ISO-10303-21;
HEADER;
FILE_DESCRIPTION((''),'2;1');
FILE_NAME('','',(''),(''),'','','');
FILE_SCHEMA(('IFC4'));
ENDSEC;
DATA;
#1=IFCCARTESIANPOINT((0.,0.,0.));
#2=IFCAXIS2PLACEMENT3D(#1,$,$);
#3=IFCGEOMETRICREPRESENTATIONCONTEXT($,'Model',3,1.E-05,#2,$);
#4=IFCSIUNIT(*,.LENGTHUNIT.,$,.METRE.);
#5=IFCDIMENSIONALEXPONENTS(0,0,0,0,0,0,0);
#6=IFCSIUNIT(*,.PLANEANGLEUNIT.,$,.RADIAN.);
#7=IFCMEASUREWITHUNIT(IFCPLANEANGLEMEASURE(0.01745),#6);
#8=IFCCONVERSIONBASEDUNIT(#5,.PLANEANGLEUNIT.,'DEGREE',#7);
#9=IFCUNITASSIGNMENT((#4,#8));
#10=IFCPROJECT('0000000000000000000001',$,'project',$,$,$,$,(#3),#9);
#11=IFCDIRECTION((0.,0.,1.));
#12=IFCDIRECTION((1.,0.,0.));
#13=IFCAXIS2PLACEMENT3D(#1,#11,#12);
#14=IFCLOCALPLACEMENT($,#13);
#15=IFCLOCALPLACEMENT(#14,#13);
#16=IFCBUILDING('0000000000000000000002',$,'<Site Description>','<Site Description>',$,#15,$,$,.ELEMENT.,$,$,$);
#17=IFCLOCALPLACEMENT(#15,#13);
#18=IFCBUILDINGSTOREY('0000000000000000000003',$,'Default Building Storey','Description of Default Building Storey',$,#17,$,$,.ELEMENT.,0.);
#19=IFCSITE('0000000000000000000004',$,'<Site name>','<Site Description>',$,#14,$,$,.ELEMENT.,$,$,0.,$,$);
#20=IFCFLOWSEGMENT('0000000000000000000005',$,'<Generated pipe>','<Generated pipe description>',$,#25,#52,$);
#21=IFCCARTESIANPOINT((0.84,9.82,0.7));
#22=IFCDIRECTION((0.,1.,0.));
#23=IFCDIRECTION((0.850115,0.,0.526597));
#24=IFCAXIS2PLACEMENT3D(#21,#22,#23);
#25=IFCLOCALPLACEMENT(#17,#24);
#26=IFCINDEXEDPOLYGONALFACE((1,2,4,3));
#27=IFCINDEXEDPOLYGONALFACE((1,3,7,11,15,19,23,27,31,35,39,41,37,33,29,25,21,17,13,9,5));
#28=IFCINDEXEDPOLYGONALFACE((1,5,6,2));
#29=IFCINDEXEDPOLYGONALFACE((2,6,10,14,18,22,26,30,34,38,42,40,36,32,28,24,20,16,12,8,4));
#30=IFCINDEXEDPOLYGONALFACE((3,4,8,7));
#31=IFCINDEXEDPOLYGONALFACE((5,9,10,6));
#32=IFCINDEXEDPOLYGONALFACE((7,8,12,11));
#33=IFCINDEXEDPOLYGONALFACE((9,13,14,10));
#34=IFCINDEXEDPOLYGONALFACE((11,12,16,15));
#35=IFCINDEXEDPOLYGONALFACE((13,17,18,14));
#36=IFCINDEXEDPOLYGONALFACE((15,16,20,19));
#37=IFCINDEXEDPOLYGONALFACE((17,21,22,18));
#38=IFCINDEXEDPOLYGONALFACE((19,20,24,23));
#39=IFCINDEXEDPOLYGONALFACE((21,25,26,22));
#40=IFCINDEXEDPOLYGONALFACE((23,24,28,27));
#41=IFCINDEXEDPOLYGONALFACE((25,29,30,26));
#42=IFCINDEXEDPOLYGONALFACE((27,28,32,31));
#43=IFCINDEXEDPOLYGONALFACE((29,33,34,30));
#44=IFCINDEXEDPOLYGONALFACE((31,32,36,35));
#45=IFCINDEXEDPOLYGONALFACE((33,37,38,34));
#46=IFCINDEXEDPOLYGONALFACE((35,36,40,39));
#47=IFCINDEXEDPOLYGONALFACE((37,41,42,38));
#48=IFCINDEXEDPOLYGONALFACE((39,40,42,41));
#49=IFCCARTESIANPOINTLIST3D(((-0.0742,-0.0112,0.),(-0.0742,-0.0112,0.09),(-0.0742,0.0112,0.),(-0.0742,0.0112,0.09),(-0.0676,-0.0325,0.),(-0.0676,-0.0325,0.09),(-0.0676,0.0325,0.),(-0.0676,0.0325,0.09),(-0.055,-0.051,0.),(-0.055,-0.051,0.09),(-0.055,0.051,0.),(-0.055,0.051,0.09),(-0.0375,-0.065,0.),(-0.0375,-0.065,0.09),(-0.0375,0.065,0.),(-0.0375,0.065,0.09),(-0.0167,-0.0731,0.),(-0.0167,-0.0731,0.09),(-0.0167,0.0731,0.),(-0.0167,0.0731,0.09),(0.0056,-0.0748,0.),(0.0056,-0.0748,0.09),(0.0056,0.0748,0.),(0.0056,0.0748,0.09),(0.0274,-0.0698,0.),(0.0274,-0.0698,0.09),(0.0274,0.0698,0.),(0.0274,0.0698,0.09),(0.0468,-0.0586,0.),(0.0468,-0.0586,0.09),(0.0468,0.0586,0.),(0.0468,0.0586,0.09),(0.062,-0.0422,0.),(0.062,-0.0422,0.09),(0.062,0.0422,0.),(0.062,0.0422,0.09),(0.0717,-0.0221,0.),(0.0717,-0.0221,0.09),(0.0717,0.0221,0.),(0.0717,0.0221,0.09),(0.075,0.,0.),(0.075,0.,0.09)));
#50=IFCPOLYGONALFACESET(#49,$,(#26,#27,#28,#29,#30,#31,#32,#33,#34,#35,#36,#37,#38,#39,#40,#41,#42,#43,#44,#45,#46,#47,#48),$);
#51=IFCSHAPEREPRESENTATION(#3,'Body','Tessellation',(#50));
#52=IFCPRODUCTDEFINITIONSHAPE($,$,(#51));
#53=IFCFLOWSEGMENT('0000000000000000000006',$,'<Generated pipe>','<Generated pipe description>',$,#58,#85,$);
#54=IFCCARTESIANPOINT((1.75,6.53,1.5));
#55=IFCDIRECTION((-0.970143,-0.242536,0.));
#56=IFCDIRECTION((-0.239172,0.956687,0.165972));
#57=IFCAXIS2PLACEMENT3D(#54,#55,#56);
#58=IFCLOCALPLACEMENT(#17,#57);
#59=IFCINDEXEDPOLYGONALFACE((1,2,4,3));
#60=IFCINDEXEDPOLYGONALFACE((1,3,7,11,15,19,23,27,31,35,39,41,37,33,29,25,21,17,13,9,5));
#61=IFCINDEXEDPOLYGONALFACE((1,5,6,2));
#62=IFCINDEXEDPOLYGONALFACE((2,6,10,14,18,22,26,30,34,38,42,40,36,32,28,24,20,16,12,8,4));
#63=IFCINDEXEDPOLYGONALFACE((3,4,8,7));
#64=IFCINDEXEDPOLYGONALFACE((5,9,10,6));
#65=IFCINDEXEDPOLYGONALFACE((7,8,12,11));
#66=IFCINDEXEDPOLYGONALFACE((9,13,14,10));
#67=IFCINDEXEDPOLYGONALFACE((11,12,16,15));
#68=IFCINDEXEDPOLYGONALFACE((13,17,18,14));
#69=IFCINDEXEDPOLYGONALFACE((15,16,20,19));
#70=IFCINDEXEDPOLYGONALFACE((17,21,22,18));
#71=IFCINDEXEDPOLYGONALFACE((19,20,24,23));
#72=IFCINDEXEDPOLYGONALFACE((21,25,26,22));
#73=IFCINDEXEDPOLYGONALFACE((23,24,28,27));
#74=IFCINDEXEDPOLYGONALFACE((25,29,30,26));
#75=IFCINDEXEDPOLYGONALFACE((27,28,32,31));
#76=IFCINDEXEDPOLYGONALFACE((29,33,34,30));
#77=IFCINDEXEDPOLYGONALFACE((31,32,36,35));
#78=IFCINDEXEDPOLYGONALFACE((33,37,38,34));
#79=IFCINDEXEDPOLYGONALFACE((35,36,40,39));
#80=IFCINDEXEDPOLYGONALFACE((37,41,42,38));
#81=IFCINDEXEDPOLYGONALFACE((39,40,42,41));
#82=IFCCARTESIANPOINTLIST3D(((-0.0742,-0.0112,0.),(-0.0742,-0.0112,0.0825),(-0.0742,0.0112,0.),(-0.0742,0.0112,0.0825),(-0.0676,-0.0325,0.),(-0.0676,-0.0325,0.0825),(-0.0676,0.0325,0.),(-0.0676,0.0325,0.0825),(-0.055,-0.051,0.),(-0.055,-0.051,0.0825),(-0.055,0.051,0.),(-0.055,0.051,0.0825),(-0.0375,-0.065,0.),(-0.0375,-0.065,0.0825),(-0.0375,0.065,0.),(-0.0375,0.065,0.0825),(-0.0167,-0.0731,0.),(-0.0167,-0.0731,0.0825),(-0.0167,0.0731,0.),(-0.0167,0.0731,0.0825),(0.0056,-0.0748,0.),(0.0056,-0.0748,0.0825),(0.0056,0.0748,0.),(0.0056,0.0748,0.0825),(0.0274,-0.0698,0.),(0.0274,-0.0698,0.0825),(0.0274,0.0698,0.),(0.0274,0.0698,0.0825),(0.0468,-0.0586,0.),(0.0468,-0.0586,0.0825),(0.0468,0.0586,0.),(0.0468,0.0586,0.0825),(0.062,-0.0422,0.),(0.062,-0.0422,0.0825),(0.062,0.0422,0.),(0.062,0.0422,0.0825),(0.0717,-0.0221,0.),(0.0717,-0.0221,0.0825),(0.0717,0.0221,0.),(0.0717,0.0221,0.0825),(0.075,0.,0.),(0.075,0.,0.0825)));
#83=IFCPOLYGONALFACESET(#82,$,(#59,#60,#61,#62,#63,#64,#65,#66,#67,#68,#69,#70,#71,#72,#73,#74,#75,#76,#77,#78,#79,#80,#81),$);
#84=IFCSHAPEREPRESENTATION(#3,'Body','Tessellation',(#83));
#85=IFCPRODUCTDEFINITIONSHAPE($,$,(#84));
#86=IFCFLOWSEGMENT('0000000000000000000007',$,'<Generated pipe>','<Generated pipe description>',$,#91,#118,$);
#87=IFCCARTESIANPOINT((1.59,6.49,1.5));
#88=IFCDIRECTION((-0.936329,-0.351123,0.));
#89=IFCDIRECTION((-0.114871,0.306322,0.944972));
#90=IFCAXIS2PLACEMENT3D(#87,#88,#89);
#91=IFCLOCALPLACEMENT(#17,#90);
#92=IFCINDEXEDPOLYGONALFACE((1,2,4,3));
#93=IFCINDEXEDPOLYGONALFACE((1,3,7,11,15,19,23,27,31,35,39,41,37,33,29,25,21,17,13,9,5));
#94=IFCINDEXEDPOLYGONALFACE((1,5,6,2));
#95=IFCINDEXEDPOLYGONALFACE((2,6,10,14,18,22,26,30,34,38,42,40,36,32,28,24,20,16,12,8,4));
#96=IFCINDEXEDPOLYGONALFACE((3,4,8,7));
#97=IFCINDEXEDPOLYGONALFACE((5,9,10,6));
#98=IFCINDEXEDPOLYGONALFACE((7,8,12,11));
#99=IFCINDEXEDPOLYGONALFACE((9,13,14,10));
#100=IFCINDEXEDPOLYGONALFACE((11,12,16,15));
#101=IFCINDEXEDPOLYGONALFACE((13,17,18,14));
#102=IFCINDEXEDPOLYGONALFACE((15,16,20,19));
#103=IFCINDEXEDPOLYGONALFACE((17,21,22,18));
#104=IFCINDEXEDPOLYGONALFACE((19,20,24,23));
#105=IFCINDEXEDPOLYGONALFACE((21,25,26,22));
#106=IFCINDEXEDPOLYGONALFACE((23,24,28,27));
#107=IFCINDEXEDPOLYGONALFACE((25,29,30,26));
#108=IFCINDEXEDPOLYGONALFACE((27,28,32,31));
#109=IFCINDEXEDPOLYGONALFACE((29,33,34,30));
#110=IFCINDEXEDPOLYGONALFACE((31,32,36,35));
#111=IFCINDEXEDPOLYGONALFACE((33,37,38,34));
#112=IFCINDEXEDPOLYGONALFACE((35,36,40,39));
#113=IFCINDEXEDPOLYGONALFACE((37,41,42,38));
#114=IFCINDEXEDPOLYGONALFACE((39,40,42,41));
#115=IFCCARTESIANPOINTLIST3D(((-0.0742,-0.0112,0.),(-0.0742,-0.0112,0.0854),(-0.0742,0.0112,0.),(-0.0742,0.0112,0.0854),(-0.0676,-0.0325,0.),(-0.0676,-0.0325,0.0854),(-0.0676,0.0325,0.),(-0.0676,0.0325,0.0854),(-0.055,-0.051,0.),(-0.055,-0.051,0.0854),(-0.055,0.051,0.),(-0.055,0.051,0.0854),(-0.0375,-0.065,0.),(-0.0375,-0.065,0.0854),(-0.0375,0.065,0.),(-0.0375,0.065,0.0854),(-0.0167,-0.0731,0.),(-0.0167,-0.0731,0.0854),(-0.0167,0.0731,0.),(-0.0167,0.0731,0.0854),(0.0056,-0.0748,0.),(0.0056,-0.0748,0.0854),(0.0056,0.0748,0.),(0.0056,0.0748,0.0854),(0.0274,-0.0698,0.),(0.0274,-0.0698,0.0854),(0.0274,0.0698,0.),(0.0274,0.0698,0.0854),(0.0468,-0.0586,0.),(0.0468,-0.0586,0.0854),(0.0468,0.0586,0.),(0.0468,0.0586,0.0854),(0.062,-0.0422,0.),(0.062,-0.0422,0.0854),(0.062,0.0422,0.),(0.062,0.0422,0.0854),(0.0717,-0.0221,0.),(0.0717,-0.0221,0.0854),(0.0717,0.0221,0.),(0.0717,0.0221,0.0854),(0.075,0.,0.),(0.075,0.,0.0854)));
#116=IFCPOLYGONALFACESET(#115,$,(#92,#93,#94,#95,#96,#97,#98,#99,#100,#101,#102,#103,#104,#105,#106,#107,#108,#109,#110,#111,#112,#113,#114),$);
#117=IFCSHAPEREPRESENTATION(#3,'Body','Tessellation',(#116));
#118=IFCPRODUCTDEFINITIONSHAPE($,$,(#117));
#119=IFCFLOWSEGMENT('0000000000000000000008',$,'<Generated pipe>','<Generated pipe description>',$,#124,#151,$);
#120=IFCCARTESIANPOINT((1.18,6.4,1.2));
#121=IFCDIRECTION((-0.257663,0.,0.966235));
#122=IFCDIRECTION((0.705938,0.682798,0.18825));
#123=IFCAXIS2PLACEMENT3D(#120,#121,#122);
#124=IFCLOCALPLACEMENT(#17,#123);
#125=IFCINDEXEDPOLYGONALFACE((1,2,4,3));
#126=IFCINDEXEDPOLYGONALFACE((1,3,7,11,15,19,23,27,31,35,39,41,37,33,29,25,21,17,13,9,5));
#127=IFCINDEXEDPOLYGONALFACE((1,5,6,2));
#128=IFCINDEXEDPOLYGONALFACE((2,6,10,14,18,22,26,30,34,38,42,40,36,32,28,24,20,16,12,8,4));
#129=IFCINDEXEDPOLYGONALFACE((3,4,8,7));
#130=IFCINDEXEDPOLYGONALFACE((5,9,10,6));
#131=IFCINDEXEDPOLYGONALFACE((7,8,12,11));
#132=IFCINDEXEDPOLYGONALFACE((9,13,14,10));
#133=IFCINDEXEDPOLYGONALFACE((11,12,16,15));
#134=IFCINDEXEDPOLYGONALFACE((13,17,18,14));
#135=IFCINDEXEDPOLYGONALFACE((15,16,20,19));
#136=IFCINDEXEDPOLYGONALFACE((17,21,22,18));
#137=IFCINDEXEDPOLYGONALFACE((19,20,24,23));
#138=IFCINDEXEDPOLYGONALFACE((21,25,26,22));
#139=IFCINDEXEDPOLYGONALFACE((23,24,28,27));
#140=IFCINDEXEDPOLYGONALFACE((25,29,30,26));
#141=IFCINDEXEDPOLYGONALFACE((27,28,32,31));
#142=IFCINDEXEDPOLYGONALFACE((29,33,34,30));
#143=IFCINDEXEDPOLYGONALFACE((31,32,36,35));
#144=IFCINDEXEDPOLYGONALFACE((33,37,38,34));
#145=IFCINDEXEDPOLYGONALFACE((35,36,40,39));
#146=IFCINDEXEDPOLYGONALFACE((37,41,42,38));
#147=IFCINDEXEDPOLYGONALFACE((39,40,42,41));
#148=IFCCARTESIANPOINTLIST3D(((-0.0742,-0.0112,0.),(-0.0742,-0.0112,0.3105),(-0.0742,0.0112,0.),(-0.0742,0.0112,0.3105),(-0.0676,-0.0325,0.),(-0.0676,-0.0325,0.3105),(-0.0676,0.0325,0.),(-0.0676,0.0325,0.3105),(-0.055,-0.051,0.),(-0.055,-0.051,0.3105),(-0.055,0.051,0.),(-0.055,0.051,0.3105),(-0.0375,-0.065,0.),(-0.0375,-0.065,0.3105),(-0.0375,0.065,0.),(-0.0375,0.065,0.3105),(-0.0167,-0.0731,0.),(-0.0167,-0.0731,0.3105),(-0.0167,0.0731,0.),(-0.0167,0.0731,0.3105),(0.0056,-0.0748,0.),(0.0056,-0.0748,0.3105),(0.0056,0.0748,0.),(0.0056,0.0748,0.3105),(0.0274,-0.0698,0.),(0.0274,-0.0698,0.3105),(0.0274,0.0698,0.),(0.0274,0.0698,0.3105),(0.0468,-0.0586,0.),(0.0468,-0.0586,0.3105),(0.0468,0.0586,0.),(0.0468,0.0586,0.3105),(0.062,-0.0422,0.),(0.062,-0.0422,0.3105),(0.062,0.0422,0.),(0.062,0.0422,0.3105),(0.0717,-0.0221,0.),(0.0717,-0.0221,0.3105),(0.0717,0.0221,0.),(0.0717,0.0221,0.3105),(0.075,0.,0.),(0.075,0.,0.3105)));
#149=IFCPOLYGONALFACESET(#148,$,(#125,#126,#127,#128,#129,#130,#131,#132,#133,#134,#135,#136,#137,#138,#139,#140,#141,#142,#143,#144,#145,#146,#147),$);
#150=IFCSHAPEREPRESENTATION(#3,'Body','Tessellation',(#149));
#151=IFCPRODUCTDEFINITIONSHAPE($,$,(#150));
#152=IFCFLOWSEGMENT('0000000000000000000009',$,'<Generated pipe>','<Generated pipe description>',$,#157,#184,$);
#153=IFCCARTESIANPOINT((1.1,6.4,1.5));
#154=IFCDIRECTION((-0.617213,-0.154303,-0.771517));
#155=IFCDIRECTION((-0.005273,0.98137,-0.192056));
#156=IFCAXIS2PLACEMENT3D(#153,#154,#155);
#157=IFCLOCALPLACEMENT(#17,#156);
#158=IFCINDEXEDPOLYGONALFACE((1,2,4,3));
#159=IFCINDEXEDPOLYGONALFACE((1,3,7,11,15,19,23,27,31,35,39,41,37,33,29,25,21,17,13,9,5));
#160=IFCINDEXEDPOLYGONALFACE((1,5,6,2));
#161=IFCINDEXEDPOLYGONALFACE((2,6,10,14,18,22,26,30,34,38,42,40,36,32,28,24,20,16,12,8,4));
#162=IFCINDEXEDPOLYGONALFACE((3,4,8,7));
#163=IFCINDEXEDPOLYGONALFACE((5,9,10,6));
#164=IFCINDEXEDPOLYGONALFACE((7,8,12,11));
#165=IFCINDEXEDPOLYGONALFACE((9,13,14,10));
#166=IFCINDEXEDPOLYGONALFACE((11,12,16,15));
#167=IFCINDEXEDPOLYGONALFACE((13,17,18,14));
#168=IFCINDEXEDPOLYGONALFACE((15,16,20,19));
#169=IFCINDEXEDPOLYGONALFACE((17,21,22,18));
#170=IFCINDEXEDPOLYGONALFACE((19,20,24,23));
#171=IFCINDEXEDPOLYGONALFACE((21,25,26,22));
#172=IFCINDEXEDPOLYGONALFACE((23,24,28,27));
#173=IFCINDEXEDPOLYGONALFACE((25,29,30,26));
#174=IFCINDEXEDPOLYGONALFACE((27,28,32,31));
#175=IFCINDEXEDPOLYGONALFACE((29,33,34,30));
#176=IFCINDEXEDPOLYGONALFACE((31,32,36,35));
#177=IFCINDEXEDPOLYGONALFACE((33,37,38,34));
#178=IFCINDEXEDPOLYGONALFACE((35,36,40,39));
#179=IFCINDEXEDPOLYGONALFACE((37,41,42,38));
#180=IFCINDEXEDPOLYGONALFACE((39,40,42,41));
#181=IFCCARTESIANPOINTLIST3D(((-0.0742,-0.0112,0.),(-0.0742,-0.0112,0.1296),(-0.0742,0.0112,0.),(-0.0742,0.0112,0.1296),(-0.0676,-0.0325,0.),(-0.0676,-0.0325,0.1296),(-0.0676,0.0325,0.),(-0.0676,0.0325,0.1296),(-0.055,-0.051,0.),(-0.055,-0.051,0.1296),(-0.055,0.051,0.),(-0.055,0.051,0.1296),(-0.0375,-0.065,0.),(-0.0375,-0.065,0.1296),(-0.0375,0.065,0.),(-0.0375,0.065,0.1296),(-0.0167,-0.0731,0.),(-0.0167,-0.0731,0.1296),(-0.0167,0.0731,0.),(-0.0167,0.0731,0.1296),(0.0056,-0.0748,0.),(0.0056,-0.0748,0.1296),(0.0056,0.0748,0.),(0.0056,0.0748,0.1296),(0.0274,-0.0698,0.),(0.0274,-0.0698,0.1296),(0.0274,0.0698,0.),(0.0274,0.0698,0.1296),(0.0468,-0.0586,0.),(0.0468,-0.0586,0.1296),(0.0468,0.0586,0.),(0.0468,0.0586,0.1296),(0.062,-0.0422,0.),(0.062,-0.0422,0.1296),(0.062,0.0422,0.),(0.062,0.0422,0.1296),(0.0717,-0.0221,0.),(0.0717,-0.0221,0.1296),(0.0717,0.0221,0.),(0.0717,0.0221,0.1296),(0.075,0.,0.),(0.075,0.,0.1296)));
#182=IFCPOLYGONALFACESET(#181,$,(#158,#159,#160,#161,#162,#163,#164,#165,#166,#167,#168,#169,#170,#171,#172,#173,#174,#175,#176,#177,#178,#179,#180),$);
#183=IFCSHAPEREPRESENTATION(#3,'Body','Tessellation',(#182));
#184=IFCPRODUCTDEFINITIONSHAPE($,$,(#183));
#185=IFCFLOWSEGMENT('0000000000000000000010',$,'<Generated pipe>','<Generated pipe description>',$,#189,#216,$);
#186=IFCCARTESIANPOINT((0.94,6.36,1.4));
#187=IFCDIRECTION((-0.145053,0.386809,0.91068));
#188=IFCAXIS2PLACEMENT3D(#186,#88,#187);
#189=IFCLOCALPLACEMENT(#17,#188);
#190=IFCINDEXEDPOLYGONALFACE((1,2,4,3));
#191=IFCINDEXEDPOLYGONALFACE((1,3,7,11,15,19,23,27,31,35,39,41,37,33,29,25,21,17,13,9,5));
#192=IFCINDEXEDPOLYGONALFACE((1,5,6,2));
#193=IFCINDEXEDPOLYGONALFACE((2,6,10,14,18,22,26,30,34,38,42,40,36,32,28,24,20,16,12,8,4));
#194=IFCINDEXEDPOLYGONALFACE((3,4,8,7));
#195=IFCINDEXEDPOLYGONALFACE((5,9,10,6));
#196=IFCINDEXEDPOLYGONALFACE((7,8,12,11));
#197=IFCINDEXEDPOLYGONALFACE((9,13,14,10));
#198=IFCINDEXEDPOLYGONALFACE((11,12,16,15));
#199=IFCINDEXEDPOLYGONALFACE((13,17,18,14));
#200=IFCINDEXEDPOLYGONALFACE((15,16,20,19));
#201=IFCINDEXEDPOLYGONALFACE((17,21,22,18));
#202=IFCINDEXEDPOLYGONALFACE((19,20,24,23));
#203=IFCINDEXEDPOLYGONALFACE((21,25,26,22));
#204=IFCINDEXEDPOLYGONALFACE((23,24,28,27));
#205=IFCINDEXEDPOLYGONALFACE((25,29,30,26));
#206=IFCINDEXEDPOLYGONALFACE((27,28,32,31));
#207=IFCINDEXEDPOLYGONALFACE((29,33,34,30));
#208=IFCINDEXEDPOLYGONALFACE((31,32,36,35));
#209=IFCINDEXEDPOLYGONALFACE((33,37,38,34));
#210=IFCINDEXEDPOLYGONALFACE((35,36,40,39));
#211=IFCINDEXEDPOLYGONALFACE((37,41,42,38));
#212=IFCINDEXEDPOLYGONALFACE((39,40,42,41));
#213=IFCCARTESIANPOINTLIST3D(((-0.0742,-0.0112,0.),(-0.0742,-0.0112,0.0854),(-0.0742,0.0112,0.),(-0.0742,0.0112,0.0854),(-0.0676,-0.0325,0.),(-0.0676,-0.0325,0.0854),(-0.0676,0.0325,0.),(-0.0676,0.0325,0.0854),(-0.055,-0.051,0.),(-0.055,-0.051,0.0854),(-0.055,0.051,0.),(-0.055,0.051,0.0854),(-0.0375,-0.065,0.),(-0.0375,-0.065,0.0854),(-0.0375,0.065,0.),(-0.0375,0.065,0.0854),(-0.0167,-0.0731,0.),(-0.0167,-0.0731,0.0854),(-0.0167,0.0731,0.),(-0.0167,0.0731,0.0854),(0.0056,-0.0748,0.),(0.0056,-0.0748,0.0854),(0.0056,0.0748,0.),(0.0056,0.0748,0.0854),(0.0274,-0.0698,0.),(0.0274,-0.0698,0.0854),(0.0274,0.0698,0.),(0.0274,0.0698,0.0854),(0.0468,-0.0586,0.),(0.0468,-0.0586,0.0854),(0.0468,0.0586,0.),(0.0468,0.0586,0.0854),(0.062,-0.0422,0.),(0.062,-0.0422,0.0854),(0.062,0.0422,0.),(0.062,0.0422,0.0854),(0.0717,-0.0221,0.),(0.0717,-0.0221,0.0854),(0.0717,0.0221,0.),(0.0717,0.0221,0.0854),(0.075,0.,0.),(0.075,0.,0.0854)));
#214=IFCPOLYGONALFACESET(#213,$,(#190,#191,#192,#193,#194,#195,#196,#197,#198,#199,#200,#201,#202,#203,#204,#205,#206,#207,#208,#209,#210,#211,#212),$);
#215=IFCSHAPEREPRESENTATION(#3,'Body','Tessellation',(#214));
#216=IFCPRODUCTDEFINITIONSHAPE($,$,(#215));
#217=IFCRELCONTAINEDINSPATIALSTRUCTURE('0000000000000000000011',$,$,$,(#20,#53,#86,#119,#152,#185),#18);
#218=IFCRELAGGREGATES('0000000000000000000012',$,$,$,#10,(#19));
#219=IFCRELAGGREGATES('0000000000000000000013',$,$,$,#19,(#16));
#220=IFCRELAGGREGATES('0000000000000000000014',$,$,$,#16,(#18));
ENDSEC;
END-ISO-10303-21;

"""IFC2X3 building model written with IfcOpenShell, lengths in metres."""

from ifc_helpers import new_model, entity, si_unit, converted_unit, frame, origin, origin_with_axes, origin_2d_with_axis, place, context, project, spatial, circle, extrude, element, save


model = new_model("IFC2X3")

# Units and contexts
model_context = context("Model", 3, precision=1e-05, world=origin())
ifc_project = project(units=[si_unit("LENGTHUNIT", "METRE"), converted_unit("PLANEANGLEUNIT", "DEGREE", entity("IfcPlaneAngleMeasure", 0.01745), si_unit("PLANEANGLEUNIT", "RADIAN"), dimensions=[0, 0, 0, 0, 0, 0, 0])], contexts=[model_context])

# Site, building, storey
site_placement = place(None, origin_with_axes())
site = spatial("IfcSite", under=ifc_project, at=site_placement, Name="<Site name>", Description="<Site Description>", CompositionType="ELEMENT", RefElevation=0.0)
building_placement = place(site_placement, origin_with_axes())
building = spatial("IfcBuilding", under=site, at=building_placement, Name="<Site Description>", Description="<Site Description>", CompositionType="ELEMENT")
storey_placement = place(building_placement, origin_with_axes())
storey = spatial("IfcBuildingStorey", under=building, at=storey_placement, Name="Default Building Storey", Description="Description of Default Building Storey", CompositionType="ELEMENT", Elevation=0.0)

# Flow segments
flow_segment_1_placement = place(storey_placement, frame((0.84, 9.82, 0.7), z_axis=(0.0, 1.0, 0.0), x_axis=(0.850115, 0.0, 0.526597)))
element("IfcFlowSegment", 1, at=flow_segment_1_placement, inside=storey, Name="<Generated pipe>", Description="<Generated pipe description>", context=model_context, shape_type="SweptSolid", body=[
    extrude(circle(Radius=0.075, at=origin_2d_with_axis()), origin_with_axes(), (0.0, 0.0, 1.0), 0.09),
])
flow_segment_2_placement = place(storey_placement, frame((1.75, 6.53, 1.5), z_axis=(-0.970143, -0.242536, 0.0), x_axis=(-0.239172, 0.956687, 0.165972)))
element("IfcFlowSegment", 2, at=flow_segment_2_placement, inside=storey, Name="<Generated pipe>", Description="<Generated pipe description>", context=model_context, shape_type="SweptSolid", body=[
    extrude(circle(Radius=0.075, at=origin_2d_with_axis()), origin_with_axes(), (0.0, 0.0, 1.0), 0.0825),
])
flow_segment_3_placement = place(storey_placement, frame((1.59, 6.49, 1.5), z_axis=(-0.936329, -0.351123, 0.0), x_axis=(-0.114871, 0.306322, 0.944972)))
element("IfcFlowSegment", 3, at=flow_segment_3_placement, inside=storey, Name="<Generated pipe>", Description="<Generated pipe description>", context=model_context, shape_type="SweptSolid", body=[
    extrude(circle(Radius=0.075, at=origin_2d_with_axis()), origin_with_axes(), (0.0, 0.0, 1.0), 0.0854),
])
flow_segment_4_placement = place(storey_placement, frame((1.18, 6.4, 1.2), z_axis=(-0.257663, 0.0, 0.966235), x_axis=(0.705938, 0.682798, 0.18825)))
element("IfcFlowSegment", 4, at=flow_segment_4_placement, inside=storey, Name="<Generated pipe>", Description="<Generated pipe description>", context=model_context, shape_type="SweptSolid", body=[
    extrude(circle(Radius=0.075, at=origin_2d_with_axis()), origin_with_axes(), (0.0, 0.0, 1.0), 0.3105),
])
flow_segment_5_placement = place(storey_placement, frame((1.1, 6.4, 1.5), z_axis=(-0.617213, -0.154303, -0.771517), x_axis=(-0.005273, 0.98137, -0.192056)))
element("IfcFlowSegment", 5, at=flow_segment_5_placement, inside=storey, Name="<Generated pipe>", Description="<Generated pipe description>", context=model_context, shape_type="SweptSolid", body=[
    extrude(circle(Radius=0.075, at=origin_2d_with_axis()), origin_with_axes(), (0.0, 0.0, 1.0), 0.1296),
])
flow_segment_6_placement = place(storey_placement, frame((0.94, 6.36, 1.4), z_axis=(-0.936329, -0.351123, 0.0), x_axis=(-0.145053, 0.386809, 0.91068)))
element("IfcFlowSegment", 6, at=flow_segment_6_placement, inside=storey, Name="<Generated pipe>", Description="<Generated pipe description>", context=model_context, shape_type="SweptSolid", body=[
    extrude(circle(Radius=0.075, at=origin_2d_with_axis()), origin_with_axes(), (0.0, 0.0, 1.0), 0.0854),
])

save(model, "model.ifc")
